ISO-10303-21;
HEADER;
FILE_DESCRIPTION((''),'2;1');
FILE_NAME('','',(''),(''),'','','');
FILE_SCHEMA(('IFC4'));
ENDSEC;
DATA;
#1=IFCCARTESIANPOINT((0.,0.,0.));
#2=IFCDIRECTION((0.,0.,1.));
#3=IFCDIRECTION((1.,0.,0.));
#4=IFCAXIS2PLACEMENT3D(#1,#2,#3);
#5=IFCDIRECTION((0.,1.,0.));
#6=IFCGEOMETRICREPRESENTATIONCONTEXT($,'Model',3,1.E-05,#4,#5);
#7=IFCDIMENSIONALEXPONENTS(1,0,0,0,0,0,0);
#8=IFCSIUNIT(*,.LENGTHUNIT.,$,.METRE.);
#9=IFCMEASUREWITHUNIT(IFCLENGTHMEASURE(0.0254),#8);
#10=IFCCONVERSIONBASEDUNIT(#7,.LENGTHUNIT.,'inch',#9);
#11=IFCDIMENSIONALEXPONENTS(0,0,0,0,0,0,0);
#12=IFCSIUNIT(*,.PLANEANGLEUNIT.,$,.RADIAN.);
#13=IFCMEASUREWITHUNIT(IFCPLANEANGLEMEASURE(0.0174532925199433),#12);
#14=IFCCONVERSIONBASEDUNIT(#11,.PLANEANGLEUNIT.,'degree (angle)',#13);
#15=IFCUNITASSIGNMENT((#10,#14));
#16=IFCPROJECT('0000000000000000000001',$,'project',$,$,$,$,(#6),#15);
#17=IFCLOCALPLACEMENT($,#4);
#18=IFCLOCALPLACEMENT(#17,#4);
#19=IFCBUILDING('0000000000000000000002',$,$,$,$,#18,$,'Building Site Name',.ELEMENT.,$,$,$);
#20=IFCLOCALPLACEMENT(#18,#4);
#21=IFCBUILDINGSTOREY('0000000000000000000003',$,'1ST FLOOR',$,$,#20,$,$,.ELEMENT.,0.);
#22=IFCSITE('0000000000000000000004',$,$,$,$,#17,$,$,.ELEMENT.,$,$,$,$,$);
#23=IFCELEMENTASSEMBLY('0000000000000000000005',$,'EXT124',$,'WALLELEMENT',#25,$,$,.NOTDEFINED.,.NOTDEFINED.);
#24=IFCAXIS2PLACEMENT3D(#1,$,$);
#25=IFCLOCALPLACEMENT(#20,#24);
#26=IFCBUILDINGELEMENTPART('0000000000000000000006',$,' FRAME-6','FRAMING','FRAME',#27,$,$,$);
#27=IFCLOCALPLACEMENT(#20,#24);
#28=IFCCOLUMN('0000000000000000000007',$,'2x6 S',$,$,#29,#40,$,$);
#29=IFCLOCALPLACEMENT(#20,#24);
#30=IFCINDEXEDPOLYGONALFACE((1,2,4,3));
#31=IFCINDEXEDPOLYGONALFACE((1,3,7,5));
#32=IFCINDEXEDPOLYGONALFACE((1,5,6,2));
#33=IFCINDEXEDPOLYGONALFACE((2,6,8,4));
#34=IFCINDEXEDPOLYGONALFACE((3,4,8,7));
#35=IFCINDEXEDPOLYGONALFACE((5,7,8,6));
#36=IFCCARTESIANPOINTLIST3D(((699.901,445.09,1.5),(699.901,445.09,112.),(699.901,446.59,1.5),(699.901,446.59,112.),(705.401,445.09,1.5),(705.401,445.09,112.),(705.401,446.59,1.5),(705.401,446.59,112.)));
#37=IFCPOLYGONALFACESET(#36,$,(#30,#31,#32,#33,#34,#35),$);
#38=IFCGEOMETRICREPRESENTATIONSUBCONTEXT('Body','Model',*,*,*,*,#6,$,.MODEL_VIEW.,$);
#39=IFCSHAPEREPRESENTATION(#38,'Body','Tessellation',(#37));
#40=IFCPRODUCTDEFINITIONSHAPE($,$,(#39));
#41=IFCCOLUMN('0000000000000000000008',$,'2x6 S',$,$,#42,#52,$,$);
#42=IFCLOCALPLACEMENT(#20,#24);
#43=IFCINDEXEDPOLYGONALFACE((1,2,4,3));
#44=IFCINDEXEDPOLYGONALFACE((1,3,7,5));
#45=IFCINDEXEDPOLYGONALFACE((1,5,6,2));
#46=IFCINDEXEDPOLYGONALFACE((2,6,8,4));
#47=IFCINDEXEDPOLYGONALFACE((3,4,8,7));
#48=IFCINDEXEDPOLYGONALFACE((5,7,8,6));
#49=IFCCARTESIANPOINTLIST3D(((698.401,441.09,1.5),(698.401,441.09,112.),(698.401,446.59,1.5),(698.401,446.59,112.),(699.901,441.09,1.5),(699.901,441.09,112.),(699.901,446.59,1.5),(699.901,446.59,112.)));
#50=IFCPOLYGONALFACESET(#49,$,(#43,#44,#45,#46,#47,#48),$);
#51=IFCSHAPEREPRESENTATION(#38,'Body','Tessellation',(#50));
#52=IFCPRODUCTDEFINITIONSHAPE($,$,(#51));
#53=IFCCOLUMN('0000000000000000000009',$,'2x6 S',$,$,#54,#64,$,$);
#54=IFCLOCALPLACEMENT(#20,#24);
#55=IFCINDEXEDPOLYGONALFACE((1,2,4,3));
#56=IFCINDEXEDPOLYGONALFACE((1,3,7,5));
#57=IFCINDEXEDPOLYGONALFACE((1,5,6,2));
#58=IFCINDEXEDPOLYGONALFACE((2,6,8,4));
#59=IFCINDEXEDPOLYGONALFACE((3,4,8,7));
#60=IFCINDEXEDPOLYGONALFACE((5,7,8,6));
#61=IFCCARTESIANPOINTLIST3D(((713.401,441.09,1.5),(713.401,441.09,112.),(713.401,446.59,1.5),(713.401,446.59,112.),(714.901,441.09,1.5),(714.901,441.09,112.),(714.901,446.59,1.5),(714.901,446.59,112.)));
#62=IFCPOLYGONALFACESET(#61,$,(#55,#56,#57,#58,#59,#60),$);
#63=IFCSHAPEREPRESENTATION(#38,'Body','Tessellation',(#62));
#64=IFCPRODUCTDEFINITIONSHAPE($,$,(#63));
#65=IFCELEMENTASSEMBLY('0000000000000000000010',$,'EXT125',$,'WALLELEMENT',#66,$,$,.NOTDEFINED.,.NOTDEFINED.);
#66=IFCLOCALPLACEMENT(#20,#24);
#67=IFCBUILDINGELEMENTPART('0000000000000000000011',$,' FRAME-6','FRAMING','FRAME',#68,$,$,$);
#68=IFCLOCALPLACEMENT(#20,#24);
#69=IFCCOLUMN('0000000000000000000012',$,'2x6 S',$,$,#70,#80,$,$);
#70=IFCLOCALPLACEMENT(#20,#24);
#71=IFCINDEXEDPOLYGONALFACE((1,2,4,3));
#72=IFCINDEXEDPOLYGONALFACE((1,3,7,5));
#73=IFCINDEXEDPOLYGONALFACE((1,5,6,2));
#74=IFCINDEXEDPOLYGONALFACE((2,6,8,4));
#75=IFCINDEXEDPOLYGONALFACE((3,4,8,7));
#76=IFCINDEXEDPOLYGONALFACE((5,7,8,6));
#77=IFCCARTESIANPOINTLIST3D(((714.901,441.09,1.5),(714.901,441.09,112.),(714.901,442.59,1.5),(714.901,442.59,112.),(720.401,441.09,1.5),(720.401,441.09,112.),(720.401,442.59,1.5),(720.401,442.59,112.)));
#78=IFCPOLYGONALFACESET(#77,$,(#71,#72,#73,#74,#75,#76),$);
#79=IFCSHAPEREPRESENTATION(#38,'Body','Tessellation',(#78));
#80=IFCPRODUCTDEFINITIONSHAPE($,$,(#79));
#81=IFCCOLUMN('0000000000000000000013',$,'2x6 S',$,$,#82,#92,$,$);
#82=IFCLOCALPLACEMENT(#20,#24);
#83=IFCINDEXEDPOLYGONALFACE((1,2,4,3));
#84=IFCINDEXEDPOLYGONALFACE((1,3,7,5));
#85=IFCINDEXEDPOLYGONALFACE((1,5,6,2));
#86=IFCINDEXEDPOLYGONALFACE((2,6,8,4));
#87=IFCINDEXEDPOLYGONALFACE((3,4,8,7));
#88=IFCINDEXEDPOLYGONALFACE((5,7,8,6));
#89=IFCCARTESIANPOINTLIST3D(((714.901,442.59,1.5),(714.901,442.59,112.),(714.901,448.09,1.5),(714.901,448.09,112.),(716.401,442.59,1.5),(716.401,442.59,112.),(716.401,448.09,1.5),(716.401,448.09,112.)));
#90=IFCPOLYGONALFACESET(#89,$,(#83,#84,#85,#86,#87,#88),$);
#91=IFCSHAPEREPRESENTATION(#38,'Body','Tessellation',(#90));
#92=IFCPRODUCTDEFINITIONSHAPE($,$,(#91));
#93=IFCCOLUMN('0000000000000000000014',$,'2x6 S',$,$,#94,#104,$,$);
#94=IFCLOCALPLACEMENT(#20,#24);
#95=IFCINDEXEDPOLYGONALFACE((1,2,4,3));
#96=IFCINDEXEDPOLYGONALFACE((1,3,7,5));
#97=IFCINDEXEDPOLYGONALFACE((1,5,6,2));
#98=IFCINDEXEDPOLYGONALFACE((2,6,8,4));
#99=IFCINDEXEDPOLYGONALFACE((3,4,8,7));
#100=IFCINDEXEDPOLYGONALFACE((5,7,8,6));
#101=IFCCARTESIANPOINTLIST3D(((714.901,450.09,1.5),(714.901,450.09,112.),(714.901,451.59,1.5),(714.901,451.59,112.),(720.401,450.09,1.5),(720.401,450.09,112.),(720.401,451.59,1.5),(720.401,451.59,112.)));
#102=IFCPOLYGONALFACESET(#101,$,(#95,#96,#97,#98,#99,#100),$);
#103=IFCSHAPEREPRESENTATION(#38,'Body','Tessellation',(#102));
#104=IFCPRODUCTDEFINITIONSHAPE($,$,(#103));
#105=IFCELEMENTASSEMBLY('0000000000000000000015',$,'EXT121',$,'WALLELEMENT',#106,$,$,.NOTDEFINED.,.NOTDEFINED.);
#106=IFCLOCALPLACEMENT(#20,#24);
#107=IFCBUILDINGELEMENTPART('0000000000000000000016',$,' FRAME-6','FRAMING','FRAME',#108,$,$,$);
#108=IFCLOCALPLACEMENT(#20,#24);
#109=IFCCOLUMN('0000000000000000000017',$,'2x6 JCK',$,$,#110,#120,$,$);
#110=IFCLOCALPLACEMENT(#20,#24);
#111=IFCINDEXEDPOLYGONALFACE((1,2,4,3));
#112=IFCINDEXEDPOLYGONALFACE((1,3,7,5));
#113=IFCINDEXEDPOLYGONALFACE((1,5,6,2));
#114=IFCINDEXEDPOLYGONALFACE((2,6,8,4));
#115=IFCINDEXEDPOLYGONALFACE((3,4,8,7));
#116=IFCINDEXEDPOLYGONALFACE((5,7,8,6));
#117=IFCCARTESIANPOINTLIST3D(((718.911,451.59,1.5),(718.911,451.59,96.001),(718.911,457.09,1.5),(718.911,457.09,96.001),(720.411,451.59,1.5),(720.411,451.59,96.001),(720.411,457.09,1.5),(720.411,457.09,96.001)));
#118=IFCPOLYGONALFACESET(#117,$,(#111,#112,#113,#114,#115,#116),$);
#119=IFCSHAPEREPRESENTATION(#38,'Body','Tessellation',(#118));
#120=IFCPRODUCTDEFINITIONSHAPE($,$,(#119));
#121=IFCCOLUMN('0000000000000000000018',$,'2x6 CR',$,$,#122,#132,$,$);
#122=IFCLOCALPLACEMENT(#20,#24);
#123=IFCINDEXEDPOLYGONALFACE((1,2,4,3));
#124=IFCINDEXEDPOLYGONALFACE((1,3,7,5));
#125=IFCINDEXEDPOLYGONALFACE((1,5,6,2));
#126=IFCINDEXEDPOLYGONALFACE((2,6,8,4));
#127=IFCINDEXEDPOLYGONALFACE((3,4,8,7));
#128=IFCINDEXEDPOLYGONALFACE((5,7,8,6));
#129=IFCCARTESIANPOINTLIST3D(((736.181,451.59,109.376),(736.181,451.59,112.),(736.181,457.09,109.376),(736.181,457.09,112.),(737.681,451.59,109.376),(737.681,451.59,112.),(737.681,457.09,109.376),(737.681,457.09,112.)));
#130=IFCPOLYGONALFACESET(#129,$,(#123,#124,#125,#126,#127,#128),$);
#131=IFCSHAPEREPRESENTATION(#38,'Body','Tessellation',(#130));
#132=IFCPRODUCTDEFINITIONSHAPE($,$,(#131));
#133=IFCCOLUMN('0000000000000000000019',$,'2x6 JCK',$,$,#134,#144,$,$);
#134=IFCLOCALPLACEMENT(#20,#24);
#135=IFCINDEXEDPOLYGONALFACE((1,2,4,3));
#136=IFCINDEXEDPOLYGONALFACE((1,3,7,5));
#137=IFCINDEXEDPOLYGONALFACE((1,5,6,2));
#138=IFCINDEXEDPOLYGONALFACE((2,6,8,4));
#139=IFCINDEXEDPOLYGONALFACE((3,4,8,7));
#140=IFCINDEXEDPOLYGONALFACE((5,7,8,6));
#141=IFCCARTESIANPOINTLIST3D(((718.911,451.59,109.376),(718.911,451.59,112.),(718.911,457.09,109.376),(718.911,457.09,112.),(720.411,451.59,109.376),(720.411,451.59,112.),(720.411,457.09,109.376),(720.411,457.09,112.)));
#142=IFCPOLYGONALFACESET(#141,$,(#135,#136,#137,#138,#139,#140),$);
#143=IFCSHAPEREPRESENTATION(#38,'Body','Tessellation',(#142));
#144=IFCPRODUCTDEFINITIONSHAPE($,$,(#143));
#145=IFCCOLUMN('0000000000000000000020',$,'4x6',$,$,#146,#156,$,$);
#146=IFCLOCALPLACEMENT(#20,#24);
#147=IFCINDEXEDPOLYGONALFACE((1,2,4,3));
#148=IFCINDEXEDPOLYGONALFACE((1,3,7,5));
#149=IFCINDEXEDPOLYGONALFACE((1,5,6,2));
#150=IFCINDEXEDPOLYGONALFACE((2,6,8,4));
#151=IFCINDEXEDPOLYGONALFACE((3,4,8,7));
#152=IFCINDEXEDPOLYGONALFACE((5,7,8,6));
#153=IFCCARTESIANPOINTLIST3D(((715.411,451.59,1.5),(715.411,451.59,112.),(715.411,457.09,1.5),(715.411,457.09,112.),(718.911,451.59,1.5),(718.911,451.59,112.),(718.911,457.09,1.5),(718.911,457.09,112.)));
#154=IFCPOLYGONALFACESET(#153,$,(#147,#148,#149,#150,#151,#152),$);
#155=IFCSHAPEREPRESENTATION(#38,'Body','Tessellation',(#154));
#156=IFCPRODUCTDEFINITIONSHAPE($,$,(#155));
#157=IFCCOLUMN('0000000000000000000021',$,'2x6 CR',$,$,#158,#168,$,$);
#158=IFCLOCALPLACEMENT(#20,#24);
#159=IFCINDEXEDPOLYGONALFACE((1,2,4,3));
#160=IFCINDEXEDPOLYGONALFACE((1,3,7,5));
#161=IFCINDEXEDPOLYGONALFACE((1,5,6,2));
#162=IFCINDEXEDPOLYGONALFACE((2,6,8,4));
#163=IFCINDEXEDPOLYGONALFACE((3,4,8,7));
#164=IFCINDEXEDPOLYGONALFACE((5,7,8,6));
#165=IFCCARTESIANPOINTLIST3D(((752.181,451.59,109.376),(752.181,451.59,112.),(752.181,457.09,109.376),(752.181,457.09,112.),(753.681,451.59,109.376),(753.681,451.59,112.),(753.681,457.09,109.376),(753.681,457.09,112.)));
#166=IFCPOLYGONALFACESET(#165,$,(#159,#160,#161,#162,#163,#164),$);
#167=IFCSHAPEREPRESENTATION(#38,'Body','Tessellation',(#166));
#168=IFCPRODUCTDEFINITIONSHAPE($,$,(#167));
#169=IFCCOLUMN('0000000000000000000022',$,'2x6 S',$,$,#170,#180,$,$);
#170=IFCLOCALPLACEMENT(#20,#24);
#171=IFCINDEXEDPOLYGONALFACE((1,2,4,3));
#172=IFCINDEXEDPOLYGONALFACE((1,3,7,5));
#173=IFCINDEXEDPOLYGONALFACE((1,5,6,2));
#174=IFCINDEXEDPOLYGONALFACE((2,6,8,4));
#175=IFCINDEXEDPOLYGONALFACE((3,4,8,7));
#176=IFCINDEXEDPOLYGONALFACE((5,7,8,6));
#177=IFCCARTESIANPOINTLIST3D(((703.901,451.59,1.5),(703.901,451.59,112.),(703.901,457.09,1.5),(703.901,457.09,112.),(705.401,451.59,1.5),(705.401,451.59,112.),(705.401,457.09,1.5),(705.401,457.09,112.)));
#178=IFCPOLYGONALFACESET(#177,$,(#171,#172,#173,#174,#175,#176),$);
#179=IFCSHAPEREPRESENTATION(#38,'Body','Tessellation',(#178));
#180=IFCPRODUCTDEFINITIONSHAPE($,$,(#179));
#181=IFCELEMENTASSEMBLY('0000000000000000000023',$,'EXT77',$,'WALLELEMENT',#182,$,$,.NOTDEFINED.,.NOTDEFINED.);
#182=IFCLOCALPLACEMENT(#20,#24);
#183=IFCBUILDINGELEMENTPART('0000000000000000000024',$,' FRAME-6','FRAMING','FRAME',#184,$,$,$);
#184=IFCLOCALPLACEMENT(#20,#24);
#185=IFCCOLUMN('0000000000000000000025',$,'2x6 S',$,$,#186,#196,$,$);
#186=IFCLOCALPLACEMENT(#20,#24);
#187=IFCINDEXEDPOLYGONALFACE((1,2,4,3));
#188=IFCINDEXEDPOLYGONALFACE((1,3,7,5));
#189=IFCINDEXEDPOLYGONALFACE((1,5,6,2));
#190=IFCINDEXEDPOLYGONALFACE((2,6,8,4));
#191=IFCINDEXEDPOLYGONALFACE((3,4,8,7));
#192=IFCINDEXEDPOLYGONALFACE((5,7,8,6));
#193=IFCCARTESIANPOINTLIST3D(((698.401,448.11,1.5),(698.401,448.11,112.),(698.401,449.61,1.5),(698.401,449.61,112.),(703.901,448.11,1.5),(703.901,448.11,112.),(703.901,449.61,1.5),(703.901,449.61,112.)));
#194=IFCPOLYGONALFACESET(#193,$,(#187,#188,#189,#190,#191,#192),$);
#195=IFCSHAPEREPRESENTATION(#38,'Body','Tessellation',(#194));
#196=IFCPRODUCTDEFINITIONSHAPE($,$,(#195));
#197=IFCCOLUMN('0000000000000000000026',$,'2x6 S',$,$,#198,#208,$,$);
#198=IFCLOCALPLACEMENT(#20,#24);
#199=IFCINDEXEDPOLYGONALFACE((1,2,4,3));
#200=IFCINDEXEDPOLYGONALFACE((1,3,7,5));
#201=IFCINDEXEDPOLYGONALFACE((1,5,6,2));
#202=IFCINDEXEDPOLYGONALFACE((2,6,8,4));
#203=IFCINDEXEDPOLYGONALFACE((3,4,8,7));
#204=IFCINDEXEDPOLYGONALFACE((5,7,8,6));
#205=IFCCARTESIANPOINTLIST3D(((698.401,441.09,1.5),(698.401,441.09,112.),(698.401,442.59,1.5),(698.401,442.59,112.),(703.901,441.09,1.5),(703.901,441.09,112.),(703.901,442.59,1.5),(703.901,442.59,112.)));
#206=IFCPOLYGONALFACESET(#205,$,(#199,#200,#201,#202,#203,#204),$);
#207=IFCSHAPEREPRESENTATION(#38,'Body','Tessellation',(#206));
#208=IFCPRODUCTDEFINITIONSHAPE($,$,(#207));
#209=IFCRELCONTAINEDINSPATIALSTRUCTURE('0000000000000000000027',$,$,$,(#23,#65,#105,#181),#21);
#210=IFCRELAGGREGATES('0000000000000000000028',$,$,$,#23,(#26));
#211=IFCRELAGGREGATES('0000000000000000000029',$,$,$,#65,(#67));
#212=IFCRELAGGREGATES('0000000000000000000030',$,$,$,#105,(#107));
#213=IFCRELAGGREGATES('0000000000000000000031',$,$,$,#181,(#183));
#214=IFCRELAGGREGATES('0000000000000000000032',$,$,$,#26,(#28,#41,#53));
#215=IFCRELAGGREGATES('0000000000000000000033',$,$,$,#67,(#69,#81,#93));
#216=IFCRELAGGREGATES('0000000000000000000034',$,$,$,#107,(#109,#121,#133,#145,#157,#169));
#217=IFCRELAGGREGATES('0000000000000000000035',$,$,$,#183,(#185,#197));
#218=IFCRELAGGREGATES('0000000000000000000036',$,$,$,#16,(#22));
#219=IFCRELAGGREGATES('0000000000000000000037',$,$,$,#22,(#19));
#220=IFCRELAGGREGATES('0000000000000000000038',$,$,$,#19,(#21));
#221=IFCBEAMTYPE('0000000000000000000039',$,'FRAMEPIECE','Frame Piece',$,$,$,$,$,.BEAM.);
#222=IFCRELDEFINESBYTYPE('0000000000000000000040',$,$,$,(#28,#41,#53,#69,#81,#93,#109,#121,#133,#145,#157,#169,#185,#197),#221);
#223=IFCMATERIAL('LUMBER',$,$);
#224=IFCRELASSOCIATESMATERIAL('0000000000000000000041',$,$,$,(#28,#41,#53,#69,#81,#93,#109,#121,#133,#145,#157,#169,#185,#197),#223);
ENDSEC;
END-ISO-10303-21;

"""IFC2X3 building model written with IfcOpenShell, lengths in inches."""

from ifc_helpers import new_model, entity, si_unit, converted_unit, direction, frame, frame_2d, origin_with_axes, place, context, subcontext, project, spatial, polyline, segment, composite_curve, rectangle, outline, extrude, material, type_object, element, aggregate, save


model = new_model("IFC2X3")

# Units and contexts
model_context = context("Model", 3, precision=1e-05, world=origin_with_axes(), true_north=direction((0.0, 1.0, 0.0)))
body_context = subcontext(model_context, "Body", "Model", "MODEL_VIEW")
ifc_project = project(units=[converted_unit("LENGTHUNIT", "inch", entity("IfcLengthMeasure", 0.0254), si_unit("LENGTHUNIT", "METRE"), dimensions=[1, 0, 0, 0, 0, 0, 0]), converted_unit("PLANEANGLEUNIT", "degree (angle)", entity("IfcPlaneAngleMeasure", 0.0174532925199433), si_unit("PLANEANGLEUNIT", "RADIAN"), dimensions=[0, 0, 0, 0, 0, 0, 0])], contexts=[model_context])

# Site, building, storey
site_placement = place(None, origin_with_axes())
site = spatial("IfcSite", under=ifc_project, at=site_placement, CompositionType="ELEMENT")
building_placement = place(site_placement, origin_with_axes())
building = spatial("IfcBuilding", under=site, at=building_placement, LongName="Building Site Name", CompositionType="ELEMENT")
storey_placement = place(building_placement, origin_with_axes())
storey = spatial("IfcBuildingStorey", under=building, at=storey_placement, Name="1ST FLOOR", CompositionType="ELEMENT", Elevation=0.0)

# Element assemblies, building element parts, columns
assembly_1_placement = place(storey_placement, origin_with_axes())
assembly_1 = element("IfcElementAssembly", 1, at=assembly_1_placement, inside=storey, Name="EXT124", ObjectType="WALLELEMENT", AssemblyPlace="NOTDEFINED", PredefinedType="NOTDEFINED")
building_element_part_1 = element("IfcBuildingElementPart", 2, Name=" FRAME-6", Description="FRAMING", ObjectType="FRAME")
aggregate(assembly_1, [building_element_part_1])
ifc_material_1 = material(Name="LUMBER")
beam_type = type_object("IfcBeamType", Name="FRAMEPIECE", Description="Frame Piece", PredefinedType="BEAM")
column_1_placement = place(assembly_1_placement, frame((702.651, 445.84, 1.5), z_axis=(0.0, 0.0, 1.0), x_axis=(0.0, -1.0, 0.0)))
column_1 = element("IfcColumn", 3, at=column_1_placement, type_object=beam_type, material=ifc_material_1, Name="2x6 S", context=body_context, shape_type="SweptSolid", body=[
    extrude(rectangle(XDim=1.5, YDim=5.5, at=frame_2d((0.0, 0.0), x_axis=(-1.0, 0.0))), frame((0.0, 0.0, 0.0), z_axis=(0.0, 0.0, 1.0), x_axis=(1.0, 0.0, 0.0)), (0.0, 0.0, 1.0), 110.5),
])
column_2_placement = place(assembly_1_placement, frame((699.151, 443.84, 1.5), z_axis=(0.0, 0.0, 1.0), x_axis=(1.0, 0.0, 0.0)))
column_2 = element("IfcColumn", 4, at=column_2_placement, type_object=beam_type, material=ifc_material_1, Name="2x6 S", context=body_context, shape_type="SweptSolid", body=[
    extrude(rectangle(XDim=1.5, YDim=5.5, at=frame_2d((0.0, 0.0), x_axis=(-1.0, 0.0))), frame((0.0, 0.0, 0.0), z_axis=(0.0, 0.0, 1.0), x_axis=(1.0, 0.0, 0.0)), (0.0, 0.0, 1.0), 110.5),
])
column_3_placement = place(assembly_1_placement, frame((714.151, 443.84, 112.0), z_axis=(0.0, 0.0, -1.0), x_axis=(-1.0, 0.0, 0.0)))
column_3 = element("IfcColumn", 5, at=column_3_placement, type_object=beam_type, material=ifc_material_1, Name="2x6 S", context=body_context, shape_type="SweptSolid", body=[
    extrude(rectangle(XDim=1.5, YDim=5.5, at=frame_2d((0.0, 0.0), x_axis=(-1.0, 0.0))), origin_with_axes(), (0.0, 0.0, 1.0), 110.5),
])
assembly_2_placement = place(storey_placement, origin_with_axes())
assembly_2 = element("IfcElementAssembly", 6, at=assembly_2_placement, inside=storey, Name="EXT125", ObjectType="WALLELEMENT", AssemblyPlace="NOTDEFINED", PredefinedType="NOTDEFINED")
building_element_part_2 = element("IfcBuildingElementPart", 7, Name=" FRAME-6", Description="FRAMING", ObjectType="FRAME")
aggregate(assembly_2, [building_element_part_2])
column_4_placement = place(assembly_2_placement, frame((717.651, 441.84, 1.5), z_axis=(0.0, 0.0, 1.0), x_axis=(0.0, 1.0, 0.0)))
column_4 = element("IfcColumn", 8, at=column_4_placement, type_object=beam_type, material=ifc_material_1, Name="2x6 S", context=body_context, shape_type="SweptSolid", body=[
    extrude(rectangle(XDim=1.5, YDim=5.5, at=frame_2d((0.0, 0.0), x_axis=(-1.0, 0.0))), frame((0.0, 0.0, 0.0), z_axis=(0.0, 0.0, 1.0), x_axis=(1.0, 0.0, 0.0)), (0.0, 0.0, 1.0), 110.5),
])
column_5_placement = place(assembly_2_placement, frame((715.651, 445.34, 1.5), z_axis=(0.0, 0.0, 1.0), x_axis=(1.0, 0.0, 0.0)))
column_5 = element("IfcColumn", 9, at=column_5_placement, type_object=beam_type, material=ifc_material_1, Name="2x6 S", context=body_context, shape_type="SweptSolid", body=[
    extrude(rectangle(XDim=1.5, YDim=5.5, at=frame_2d((0.0, 0.0), x_axis=(-1.0, 0.0))), frame((0.0, 0.0, 0.0), z_axis=(0.0, 0.0, 1.0), x_axis=(1.0, 0.0, 0.0)), (0.0, 0.0, 1.0), 110.5),
])
column_6_placement = place(assembly_2_placement, frame((717.651, 450.84, 112.0), z_axis=(0.0, 0.0, -1.0), x_axis=(0.0, -1.0, 0.0)))
column_6 = element("IfcColumn", 10, at=column_6_placement, type_object=beam_type, material=ifc_material_1, Name="2x6 S", context=body_context, shape_type="SweptSolid", body=[
    extrude(rectangle(XDim=1.5, YDim=5.5, at=frame_2d((0.0, 0.0), x_axis=(-1.0, 0.0))), origin_with_axes(), (0.0, 0.0, 1.0), 110.5),
])
assembly_3_placement = place(storey_placement, origin_with_axes())
assembly_3 = element("IfcElementAssembly", 11, at=assembly_3_placement, inside=storey, Name="EXT121", ObjectType="WALLELEMENT", AssemblyPlace="NOTDEFINED", PredefinedType="NOTDEFINED")
building_element_part_3 = element("IfcBuildingElementPart", 12, Name=" FRAME-6", Description="FRAMING", ObjectType="FRAME")
aggregate(assembly_3, [building_element_part_3])
column_7_placement = place(assembly_3_placement, frame((719.661, 454.34, 1.5), z_axis=(0.0, 0.0, 1.0), x_axis=(1.0, 0.0, 0.0)))
column_7 = element("IfcColumn", 13, at=column_7_placement, type_object=beam_type, material=ifc_material_1, Name="2x6 JCK", context=body_context, shape_type="SweptSolid", body=[
    extrude(rectangle(XDim=1.5, YDim=5.5, at=frame_2d((0.0, 0.0), x_axis=(-1.0, 0.0))), frame((0.0, 0.0, 0.0), z_axis=(0.0, 0.0, 1.0), x_axis=(1.0, 0.0, 0.0)), (0.0, 0.0, 1.0), 94.501),
])
column_8_placement = place(assembly_3_placement, frame((736.931, 454.34, 112.0), z_axis=(0.0, 0.0, -1.0), x_axis=(-1.0, 0.0, 0.0)))
column_8 = element("IfcColumn", 14, at=column_8_placement, type_object=beam_type, material=ifc_material_1, Name="2x6 CR", context=body_context, shape_type="SweptSolid", body=[
    extrude(rectangle(XDim=1.5, YDim=5.5, at=frame_2d((0.0, 0.0), x_axis=(-1.0, 0.0))), origin_with_axes(), (0.0, 0.0, 1.0), 2.624),
])
column_9_placement = place(assembly_3_placement, frame((719.661, 454.34, 109.376), z_axis=(0.0, 0.0, 1.0), x_axis=(1.0, 0.0, 0.0)))
column_9 = element("IfcColumn", 15, at=column_9_placement, type_object=beam_type, material=ifc_material_1, Name="2x6 JCK", context=body_context, shape_type="SweptSolid", body=[
    extrude(rectangle(XDim=1.5, YDim=5.5, at=frame_2d((0.0, 0.0), x_axis=(-1.0, 0.0))), origin_with_axes(), (0.0, 0.0, 1.0), 2.624),
])
column_10_placement = place(assembly_3_placement, frame((717.161, 454.34, 1.5), z_axis=(0.0, 0.0, 1.0), x_axis=(1.0, 0.0, 0.0)))
column_10 = element("IfcColumn", 16, at=column_10_placement, type_object=beam_type, material=ifc_material_1, Name="4x6", context=body_context, shape_type="SweptSolid", body=[
    extrude(outline(composite_curve([segment(polyline([(-1.75, -2.75), (-1.75, 2.75), (1.75, 2.75), (1.75, -2.75), (-1.75, -2.75)]), True, "CONTINUOUS")], self_intersect=False)), origin_with_axes(), (0.0, 0.0, 1.0), 110.5),
])
column_11_placement = place(assembly_3_placement, frame((752.931, 454.34, 112.0), z_axis=(0.0, 0.0, -1.0), x_axis=(-1.0, 0.0, 0.0)))
column_11 = element("IfcColumn", 17, at=column_11_placement, type_object=beam_type, material=ifc_material_1, Name="2x6 CR", context=body_context, shape_type="SweptSolid", body=[
    extrude(rectangle(XDim=1.5, YDim=5.5, at=frame_2d((0.0, 0.0), x_axis=(-1.0, 0.0))), origin_with_axes(), (0.0, 0.0, 1.0), 2.624),
])
column_12_placement = place(assembly_3_placement, frame((704.651, 454.34, 1.5), z_axis=(0.0, 0.0, 1.0), x_axis=(1.0, 0.0, 0.0)))
column_12 = element("IfcColumn", 18, at=column_12_placement, type_object=beam_type, material=ifc_material_1, Name="2x6 S", context=body_context, shape_type="SweptSolid", body=[
    extrude(rectangle(XDim=1.5, YDim=5.5, at=frame_2d((0.0, 0.0), x_axis=(-1.0, 0.0))), frame((0.0, 0.0, 0.0), z_axis=(0.0, 0.0, 1.0), x_axis=(1.0, 0.0, 0.0)), (0.0, 0.0, 1.0), 110.5),
])
assembly_4_placement = place(storey_placement, origin_with_axes())
assembly_4 = element("IfcElementAssembly", 19, at=assembly_4_placement, inside=storey, Name="EXT77", ObjectType="WALLELEMENT", AssemblyPlace="NOTDEFINED", PredefinedType="NOTDEFINED")
building_element_part_4 = element("IfcBuildingElementPart", 20, Name=" FRAME-6", Description="FRAMING", ObjectType="FRAME")
aggregate(assembly_4, [building_element_part_4])
column_13_placement = place(assembly_4_placement, frame((701.151, 448.86, 112.0), z_axis=(0.0, 0.0, -1.0), x_axis=(0.0, -1.0, 0.0)))
column_13 = element("IfcColumn", 21, at=column_13_placement, type_object=beam_type, material=ifc_material_1, Name="2x6 S", context=body_context, shape_type="SweptSolid", body=[
    extrude(rectangle(XDim=1.5, YDim=5.5, at=frame_2d((0.0, 0.0), x_axis=(-1.0, 0.0))), origin_with_axes(), (0.0, 0.0, 1.0), 110.5),
])
column_14_placement = place(assembly_4_placement, frame((701.151, 441.84, 1.5), z_axis=(0.0, 0.0, 1.0), x_axis=(0.0, 1.0, 0.0)))
column_14 = element("IfcColumn", 22, at=column_14_placement, type_object=beam_type, material=ifc_material_1, Name="2x6 S", context=body_context, shape_type="SweptSolid", body=[
    extrude(rectangle(XDim=1.5, YDim=5.5, at=frame_2d((0.0, 0.0), x_axis=(-1.0, 0.0))), frame((0.0, 0.0, 0.0), z_axis=(0.0, 0.0, 1.0), x_axis=(1.0, 0.0, 0.0)), (0.0, 0.0, 1.0), 110.5),
])

aggregate(building_element_part_1, [column_1, column_2, column_3])
aggregate(building_element_part_2, [column_4, column_5, column_6])
aggregate(building_element_part_3, [column_7, column_8, column_9, column_10, column_11, column_12])
aggregate(building_element_part_4, [column_13, column_14])

save(model, "model.ifc")
